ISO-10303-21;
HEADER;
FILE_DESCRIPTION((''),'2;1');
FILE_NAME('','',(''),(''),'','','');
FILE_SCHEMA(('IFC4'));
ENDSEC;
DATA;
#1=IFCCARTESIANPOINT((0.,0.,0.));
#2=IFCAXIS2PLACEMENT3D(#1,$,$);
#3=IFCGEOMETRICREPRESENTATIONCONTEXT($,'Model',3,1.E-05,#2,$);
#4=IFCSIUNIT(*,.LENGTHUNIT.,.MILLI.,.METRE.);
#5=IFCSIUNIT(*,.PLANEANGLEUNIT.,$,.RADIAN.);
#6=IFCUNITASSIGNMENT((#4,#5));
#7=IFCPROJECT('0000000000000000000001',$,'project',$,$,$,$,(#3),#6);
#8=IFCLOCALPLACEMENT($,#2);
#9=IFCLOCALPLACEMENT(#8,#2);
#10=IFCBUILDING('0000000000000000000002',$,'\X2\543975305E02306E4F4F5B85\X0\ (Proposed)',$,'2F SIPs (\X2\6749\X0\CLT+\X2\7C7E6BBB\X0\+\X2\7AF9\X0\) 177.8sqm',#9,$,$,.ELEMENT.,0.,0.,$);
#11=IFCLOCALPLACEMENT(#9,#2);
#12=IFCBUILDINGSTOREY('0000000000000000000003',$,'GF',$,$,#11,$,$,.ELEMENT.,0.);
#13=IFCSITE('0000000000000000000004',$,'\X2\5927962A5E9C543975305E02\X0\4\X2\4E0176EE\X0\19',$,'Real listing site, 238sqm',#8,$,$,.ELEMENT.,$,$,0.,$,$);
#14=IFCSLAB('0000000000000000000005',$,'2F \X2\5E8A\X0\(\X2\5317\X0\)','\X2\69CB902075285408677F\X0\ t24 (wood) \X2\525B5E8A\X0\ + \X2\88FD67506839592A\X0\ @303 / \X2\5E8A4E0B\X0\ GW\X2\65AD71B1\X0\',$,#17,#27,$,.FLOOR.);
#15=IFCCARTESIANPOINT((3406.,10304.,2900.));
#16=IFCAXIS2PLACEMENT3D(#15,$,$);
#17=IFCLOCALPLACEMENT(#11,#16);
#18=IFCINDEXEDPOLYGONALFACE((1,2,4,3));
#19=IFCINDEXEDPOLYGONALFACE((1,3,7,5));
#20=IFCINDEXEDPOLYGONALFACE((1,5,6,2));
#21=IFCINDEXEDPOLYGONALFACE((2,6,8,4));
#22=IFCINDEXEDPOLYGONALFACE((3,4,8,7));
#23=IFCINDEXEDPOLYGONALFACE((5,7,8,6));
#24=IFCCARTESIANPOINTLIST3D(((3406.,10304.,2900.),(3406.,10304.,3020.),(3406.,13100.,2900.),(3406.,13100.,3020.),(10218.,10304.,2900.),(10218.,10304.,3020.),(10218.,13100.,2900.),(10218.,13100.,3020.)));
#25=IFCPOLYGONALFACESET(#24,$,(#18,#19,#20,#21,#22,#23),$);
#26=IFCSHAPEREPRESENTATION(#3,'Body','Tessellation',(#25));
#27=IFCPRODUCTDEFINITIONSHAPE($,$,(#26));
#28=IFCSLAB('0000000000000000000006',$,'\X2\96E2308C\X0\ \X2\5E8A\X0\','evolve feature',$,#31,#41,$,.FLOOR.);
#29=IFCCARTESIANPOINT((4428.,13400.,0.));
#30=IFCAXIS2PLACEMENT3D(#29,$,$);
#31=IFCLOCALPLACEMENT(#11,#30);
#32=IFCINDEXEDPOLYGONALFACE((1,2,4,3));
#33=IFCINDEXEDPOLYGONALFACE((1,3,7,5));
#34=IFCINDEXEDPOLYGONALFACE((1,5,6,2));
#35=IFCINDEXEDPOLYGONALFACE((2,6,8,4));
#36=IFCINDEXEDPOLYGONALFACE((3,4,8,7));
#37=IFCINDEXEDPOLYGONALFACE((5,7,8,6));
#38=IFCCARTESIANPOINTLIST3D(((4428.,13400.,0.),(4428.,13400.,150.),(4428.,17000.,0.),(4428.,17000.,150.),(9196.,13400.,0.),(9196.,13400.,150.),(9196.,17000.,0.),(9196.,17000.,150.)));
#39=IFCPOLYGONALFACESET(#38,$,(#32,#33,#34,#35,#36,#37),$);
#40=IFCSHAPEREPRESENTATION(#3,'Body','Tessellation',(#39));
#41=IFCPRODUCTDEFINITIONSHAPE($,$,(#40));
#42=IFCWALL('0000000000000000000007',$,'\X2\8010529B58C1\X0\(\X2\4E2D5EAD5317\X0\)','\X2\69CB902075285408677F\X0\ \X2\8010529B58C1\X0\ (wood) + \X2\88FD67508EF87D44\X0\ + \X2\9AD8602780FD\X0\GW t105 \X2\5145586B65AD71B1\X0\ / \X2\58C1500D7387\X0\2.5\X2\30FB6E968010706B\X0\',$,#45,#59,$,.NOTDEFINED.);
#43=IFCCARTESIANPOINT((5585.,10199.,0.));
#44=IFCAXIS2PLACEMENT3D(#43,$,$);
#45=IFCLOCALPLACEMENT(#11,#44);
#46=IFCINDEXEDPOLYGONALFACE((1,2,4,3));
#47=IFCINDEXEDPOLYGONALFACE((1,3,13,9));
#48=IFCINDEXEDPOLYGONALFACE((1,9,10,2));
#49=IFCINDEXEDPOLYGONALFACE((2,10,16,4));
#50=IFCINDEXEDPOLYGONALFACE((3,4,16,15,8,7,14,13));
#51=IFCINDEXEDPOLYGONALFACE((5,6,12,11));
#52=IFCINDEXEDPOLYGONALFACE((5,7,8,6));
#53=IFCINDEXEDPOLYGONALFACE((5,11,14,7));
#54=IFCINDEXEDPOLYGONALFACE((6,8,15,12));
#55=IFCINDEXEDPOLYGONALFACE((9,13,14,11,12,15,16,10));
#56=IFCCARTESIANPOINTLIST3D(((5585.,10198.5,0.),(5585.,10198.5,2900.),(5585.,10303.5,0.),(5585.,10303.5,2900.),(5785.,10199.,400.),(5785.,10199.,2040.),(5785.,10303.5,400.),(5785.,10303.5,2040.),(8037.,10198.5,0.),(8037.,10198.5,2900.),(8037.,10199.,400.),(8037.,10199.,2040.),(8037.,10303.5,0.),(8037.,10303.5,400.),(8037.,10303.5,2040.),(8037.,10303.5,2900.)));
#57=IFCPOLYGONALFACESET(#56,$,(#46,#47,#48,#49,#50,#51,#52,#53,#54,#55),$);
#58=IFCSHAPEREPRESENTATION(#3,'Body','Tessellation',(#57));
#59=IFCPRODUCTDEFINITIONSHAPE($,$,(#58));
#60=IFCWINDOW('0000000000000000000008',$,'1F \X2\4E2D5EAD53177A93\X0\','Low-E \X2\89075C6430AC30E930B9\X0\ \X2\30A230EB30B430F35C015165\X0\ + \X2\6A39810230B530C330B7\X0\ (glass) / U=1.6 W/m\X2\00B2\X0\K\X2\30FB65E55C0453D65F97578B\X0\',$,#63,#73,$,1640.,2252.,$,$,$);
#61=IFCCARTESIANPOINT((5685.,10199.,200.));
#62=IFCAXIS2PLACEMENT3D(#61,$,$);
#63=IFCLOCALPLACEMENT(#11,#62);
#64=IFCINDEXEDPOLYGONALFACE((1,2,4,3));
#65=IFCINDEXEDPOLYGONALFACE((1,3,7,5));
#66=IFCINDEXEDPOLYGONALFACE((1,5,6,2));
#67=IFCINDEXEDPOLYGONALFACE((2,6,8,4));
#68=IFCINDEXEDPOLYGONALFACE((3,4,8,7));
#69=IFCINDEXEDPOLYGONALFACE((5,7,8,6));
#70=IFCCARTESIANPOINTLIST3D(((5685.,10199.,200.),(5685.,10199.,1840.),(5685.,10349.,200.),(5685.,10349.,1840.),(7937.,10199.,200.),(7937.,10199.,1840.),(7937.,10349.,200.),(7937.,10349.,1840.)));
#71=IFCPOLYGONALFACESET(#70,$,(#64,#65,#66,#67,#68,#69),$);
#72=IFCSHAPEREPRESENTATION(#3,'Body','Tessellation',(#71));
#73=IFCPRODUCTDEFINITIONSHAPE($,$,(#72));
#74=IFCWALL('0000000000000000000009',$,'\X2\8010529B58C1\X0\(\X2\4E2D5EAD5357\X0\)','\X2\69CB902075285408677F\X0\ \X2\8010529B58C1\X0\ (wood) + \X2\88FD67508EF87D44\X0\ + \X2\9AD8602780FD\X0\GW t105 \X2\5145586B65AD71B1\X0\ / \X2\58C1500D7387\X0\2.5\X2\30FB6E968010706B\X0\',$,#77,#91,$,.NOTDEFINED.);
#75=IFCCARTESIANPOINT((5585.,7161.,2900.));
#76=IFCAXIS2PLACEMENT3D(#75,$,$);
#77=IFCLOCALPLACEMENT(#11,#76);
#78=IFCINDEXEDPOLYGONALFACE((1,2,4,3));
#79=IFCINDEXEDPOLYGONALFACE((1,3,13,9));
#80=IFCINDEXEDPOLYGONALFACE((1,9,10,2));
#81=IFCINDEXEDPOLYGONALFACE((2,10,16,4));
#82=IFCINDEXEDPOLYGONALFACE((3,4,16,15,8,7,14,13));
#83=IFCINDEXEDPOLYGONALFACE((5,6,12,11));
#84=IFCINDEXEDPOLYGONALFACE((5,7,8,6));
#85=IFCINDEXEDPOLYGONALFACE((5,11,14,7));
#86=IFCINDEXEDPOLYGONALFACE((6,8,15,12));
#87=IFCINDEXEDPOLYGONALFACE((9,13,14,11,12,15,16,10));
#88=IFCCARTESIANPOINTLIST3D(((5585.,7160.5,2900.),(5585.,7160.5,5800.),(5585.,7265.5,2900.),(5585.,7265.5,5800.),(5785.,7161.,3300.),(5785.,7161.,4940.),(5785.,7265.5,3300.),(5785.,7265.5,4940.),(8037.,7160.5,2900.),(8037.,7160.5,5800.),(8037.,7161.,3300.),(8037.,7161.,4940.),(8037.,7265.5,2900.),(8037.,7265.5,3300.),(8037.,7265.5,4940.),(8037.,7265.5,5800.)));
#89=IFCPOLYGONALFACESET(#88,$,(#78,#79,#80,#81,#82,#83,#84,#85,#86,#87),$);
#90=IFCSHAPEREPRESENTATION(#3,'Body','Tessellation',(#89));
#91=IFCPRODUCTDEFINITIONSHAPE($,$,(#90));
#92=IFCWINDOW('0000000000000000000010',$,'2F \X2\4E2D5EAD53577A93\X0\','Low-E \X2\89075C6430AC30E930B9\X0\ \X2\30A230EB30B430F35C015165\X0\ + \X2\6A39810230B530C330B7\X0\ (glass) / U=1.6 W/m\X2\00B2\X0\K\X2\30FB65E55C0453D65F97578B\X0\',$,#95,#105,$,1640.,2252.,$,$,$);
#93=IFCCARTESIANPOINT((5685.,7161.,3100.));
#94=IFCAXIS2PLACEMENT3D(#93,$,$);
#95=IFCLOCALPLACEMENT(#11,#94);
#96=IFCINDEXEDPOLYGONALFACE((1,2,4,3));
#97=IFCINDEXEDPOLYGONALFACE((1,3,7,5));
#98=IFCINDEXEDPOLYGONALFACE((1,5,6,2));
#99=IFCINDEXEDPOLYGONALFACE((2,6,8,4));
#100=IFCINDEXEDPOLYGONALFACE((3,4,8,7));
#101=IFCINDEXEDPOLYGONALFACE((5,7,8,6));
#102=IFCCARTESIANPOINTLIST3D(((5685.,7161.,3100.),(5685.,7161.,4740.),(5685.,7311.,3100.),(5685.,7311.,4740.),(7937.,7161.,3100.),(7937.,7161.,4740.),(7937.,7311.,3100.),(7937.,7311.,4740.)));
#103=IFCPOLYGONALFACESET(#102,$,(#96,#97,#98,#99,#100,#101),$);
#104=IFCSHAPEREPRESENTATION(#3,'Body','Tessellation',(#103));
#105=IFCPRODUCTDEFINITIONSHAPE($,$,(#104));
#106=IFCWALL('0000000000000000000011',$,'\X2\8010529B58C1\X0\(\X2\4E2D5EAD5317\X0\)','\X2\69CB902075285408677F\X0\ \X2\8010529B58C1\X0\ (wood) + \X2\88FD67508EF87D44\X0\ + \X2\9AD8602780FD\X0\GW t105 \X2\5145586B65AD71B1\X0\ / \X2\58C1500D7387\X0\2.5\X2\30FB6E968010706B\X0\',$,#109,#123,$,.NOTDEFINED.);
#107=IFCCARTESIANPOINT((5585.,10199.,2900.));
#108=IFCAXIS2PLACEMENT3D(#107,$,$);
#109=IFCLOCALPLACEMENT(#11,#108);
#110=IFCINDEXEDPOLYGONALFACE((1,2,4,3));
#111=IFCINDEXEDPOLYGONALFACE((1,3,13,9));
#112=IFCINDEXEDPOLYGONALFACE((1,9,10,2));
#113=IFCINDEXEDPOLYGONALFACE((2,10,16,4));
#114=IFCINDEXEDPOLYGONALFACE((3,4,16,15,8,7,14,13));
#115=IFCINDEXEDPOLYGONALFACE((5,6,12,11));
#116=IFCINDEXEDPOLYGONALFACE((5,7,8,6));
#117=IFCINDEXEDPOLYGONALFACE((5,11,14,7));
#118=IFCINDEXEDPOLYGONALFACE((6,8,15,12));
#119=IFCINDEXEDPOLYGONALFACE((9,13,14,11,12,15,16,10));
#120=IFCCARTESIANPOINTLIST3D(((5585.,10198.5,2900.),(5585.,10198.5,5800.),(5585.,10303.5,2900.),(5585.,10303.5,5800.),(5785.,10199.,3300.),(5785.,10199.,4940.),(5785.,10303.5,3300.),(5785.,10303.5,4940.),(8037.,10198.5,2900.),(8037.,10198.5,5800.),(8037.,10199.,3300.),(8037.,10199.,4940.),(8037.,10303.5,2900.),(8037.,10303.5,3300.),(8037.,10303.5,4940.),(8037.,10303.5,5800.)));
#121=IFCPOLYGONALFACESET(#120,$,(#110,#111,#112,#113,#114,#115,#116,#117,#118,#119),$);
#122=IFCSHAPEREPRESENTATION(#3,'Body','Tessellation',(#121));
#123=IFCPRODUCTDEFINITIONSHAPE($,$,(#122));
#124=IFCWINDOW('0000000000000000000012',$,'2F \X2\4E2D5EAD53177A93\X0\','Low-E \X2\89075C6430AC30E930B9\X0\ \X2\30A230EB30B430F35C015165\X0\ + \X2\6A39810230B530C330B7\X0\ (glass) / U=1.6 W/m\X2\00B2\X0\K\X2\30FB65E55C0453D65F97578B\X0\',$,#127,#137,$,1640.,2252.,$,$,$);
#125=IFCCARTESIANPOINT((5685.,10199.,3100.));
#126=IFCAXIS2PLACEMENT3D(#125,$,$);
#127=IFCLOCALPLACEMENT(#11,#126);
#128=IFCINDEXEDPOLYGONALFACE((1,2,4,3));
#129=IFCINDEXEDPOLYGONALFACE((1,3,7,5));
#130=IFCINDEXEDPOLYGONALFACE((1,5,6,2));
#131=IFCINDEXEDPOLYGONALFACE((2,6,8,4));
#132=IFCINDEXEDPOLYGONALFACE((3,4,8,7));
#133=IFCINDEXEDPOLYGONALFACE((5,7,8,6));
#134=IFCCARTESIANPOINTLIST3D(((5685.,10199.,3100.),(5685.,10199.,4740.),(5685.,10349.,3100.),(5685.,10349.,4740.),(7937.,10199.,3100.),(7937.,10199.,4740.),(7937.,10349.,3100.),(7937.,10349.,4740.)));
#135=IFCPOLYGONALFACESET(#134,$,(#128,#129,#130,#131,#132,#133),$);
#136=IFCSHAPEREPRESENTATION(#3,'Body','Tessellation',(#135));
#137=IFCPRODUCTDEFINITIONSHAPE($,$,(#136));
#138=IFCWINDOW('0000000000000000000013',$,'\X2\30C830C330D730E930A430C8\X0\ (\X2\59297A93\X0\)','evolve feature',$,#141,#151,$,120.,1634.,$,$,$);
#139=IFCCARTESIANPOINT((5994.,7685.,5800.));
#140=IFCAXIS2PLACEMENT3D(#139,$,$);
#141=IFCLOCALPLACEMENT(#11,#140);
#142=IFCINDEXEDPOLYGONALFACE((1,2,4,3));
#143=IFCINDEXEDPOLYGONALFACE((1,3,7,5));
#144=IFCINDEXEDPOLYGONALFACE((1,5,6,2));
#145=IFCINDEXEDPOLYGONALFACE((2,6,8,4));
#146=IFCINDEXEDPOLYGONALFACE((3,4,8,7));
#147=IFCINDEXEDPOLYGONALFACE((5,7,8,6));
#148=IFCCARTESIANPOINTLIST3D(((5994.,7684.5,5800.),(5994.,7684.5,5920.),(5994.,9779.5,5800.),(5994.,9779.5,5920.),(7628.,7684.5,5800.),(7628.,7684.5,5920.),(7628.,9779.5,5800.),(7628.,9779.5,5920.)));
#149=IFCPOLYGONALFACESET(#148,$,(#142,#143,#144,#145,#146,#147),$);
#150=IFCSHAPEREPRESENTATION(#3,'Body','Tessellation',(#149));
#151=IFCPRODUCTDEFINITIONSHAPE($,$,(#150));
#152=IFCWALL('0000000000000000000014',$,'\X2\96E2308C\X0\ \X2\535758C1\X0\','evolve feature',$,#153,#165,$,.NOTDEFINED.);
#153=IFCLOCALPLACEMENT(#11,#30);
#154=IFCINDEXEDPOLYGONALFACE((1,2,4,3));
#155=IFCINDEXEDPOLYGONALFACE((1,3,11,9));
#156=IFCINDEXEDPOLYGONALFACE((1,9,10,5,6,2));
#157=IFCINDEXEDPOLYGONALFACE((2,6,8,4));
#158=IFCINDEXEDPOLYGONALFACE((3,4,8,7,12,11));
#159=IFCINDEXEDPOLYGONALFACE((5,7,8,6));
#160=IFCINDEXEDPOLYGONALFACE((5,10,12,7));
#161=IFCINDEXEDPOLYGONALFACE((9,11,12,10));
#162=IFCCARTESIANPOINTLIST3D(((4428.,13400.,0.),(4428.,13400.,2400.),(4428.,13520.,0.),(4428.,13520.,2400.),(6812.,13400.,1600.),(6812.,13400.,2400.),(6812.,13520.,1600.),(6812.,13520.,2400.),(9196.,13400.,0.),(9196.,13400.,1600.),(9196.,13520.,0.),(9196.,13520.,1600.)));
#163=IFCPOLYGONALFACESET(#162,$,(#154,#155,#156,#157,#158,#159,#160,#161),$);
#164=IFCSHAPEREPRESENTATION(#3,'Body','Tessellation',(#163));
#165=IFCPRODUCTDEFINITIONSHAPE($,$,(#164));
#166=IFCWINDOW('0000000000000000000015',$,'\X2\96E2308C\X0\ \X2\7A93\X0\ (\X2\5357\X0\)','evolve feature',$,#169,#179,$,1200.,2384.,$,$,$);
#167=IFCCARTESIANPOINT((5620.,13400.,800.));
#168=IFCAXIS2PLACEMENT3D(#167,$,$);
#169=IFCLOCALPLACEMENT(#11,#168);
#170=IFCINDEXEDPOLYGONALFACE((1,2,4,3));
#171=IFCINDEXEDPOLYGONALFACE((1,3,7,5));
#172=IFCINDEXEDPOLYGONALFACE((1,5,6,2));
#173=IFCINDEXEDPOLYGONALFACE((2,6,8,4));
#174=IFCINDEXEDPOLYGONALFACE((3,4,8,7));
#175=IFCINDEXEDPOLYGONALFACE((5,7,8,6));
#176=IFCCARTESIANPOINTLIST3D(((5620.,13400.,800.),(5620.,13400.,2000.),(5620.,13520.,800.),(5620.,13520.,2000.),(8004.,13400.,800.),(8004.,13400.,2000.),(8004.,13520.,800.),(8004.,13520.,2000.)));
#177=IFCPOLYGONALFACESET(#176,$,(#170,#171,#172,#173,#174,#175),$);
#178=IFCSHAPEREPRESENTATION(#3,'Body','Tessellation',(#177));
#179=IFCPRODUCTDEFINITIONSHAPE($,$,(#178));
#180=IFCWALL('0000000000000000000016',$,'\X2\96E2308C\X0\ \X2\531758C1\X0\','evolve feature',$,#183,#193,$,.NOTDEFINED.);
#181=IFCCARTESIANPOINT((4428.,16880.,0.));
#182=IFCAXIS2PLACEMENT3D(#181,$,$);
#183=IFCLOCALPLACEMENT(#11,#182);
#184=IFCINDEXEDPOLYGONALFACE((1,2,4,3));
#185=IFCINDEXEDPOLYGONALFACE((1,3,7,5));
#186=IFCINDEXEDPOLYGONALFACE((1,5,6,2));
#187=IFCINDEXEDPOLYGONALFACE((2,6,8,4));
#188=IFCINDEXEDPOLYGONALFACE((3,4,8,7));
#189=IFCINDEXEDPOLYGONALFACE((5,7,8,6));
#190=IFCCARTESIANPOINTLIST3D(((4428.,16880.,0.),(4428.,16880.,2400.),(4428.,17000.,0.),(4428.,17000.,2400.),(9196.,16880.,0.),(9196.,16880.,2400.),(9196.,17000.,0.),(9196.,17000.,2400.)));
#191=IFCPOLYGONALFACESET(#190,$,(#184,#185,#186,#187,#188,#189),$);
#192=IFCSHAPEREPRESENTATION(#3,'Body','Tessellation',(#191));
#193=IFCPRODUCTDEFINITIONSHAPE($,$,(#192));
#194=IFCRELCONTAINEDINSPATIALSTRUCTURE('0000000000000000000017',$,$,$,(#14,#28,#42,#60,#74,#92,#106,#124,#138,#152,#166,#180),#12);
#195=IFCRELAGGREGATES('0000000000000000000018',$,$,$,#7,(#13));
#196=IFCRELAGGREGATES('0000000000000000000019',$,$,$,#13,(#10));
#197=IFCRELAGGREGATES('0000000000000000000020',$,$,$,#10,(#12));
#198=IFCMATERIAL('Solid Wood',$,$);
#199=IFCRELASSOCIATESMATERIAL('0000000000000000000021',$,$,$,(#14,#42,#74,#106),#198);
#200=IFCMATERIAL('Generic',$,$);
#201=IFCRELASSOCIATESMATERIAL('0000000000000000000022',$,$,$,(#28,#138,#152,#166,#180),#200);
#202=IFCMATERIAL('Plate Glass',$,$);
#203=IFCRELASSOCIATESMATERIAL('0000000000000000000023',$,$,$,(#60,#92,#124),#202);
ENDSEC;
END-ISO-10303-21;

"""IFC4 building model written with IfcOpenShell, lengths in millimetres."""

from ifc_helpers import new_model, si_unit, frame, frame_2d, origin, place, context, project, spatial, rectangle, extrude, material, element, fill, save


model = new_model("IFC4")

# Units and contexts
model_context = context("Model", 3, precision=1e-05, world=origin())
ifc_project = project(units=[si_unit("LENGTHUNIT", "METRE", prefix="MILLI"), si_unit("PLANEANGLEUNIT", "RADIAN")], contexts=[model_context])

# Site, building, storey
site_placement = place(None, origin())
site = spatial("IfcSite", under=ifc_project, at=site_placement, Name="大阪府吹田市4丁目19", ObjectType="Real listing site, 238sqm", CompositionType="ELEMENT", RefElevation=0.0)
building_placement = place(site_placement, origin())
building = spatial("IfcBuilding", under=site, at=building_placement, Name="吹田市の住宅 (Proposed)", ObjectType="2F SIPs (杉CLT+籾殻+竹) 177.8sqm", CompositionType="ELEMENT", ElevationOfRefHeight=0.0, ElevationOfTerrain=0.0)
storey_placement = place(building_placement, origin())
storey = spatial("IfcBuildingStorey", under=building, at=storey_placement, Name="GF", CompositionType="ELEMENT", Elevation=0.0)

# Slabs
ifc_material_1 = material(Name="Solid Wood")
slab_1_placement = place(storey_placement, frame((3406.0, 10304.0, 2900.0)))
element("IfcSlab", 1, at=slab_1_placement, inside=storey, material=ifc_material_1, Name="2F 床(北)", Description="構造用合板 t24 (wood) 剛床 + 製材根太 @303 / 床下 GW断熱", PredefinedType="FLOOR", context=model_context, shape_type="SweptSolid", body=[
    extrude(rectangle(XDim=6812.0, YDim=2796.0, at=frame_2d((3406.0, 1398.0))), frame((3406.0, 10304.0, 2900.0)), (0.0, 0.0, 1.0), 120.0),
])
ifc_material_2 = material(Name="Generic")
slab_2_placement = place(storey_placement, frame((4428.0, 13400.0, 0.0)))
element("IfcSlab", 2, at=slab_2_placement, inside=storey, material=ifc_material_2, Name="離れ 床", Description="evolve feature", PredefinedType="FLOOR", context=model_context, shape_type="SweptSolid", body=[
    extrude(rectangle(XDim=4768.0, YDim=3600.0, at=frame_2d((2384.0, 1800.0))), frame((4428.0, 13400.0, 0.0)), (0.0, 0.0, 1.0), 150.0),
])

# Wall, opening, window
wall_1_placement = place(storey_placement, frame((5585.0, 10199.0, 0.0)))
wall_1 = element("IfcWall", 3, at=wall_1_placement, inside=storey, material=ifc_material_1, Name="耐力壁(中庭北)", Description="構造用合板 耐力壁 (wood) + 製材軸組 + 高性能GW t105 充填断熱 / 壁倍率2.5・準耐火", PredefinedType="NOTDEFINED", context=model_context, shape_type="SweptSolid", body=[
    extrude(rectangle(XDim=2452.0, YDim=105.0, at=frame_2d((1226.0, 52.0))), frame((5585.0, 10199.0, 0.0)), (0.0, 0.0, 1.0), 2900.0),
])
opening_1_placement = place(storey_placement, frame((5685.0, 10199.0, 200.0)))
opening_1 = element("IfcOpeningElement", 4, at=opening_1_placement, cuts=wall_1, PredefinedType="NOTDEFINED", context=model_context, shape_type="SweptSolid", body=[
    extrude(rectangle(XDim=2252.0, YDim=150.0, at=frame_2d((1126.0, 75.0))), frame((5685.0, 10199.0, 200.0)), (0.0, 0.0, 1.0), 1640.0),
])
ifc_material_3 = material(Name="Plate Glass")
window_1_placement = place(storey_placement, frame((5685.0, 10199.0, 200.0)))
window_1 = element("IfcWindow", 5, at=window_1_placement, inside=storey, material=ifc_material_3, Name="1F 中庭北窓", Description="Low-E 複層ガラス アルゴン封入 + 樹脂サッシ (glass) / U=1.6 W/m²K・日射取得型", OverallHeight=1640.0, OverallWidth=2252.0, context=model_context, shape_type="SweptSolid", body=[
    extrude(rectangle(XDim=2252.0, YDim=150.0, at=frame_2d((1126.0, 75.0))), frame((5685.0, 10199.0, 200.0)), (0.0, 0.0, 1.0), 1640.0),
])
fill(opening_1, window_1)

# Walls, openings, windows
wall_2_placement = place(storey_placement, frame((5585.0, 7161.0, 2900.0)))
wall_2 = element("IfcWall", 6, at=wall_2_placement, inside=storey, material=ifc_material_1, Name="耐力壁(中庭南)", Description="構造用合板 耐力壁 (wood) + 製材軸組 + 高性能GW t105 充填断熱 / 壁倍率2.5・準耐火", PredefinedType="NOTDEFINED", context=model_context, shape_type="SweptSolid", body=[
    extrude(rectangle(XDim=2452.0, YDim=105.0, at=frame_2d((1226.0, 52.0))), frame((5585.0, 7161.0, 2900.0)), (0.0, 0.0, 1.0), 2900.0),
])
opening_2_placement = place(storey_placement, frame((5685.0, 7161.0, 3100.0)))
opening_2 = element("IfcOpeningElement", 7, at=opening_2_placement, cuts=wall_2, PredefinedType="NOTDEFINED", context=model_context, shape_type="SweptSolid", body=[
    extrude(rectangle(XDim=2252.0, YDim=150.0, at=frame_2d((1126.0, 75.0))), frame((5685.0, 7161.0, 3100.0)), (0.0, 0.0, 1.0), 1640.0),
])
window_2_placement = place(storey_placement, frame((5685.0, 7161.0, 3100.0)))
window_2 = element("IfcWindow", 8, at=window_2_placement, inside=storey, material=ifc_material_3, Name="2F 中庭南窓", Description="Low-E 複層ガラス アルゴン封入 + 樹脂サッシ (glass) / U=1.6 W/m²K・日射取得型", OverallHeight=1640.0, OverallWidth=2252.0, context=model_context, shape_type="SweptSolid", body=[
    extrude(rectangle(XDim=2252.0, YDim=150.0, at=frame_2d((1126.0, 75.0))), frame((5685.0, 7161.0, 3100.0)), (0.0, 0.0, 1.0), 1640.0),
])
fill(opening_2, window_2)
wall_3_placement = place(storey_placement, frame((5585.0, 10199.0, 2900.0)))
wall_3 = element("IfcWall", 9, at=wall_3_placement, inside=storey, material=ifc_material_1, Name="耐力壁(中庭北)", Description="構造用合板 耐力壁 (wood) + 製材軸組 + 高性能GW t105 充填断熱 / 壁倍率2.5・準耐火", PredefinedType="NOTDEFINED", context=model_context, shape_type="SweptSolid", body=[
    extrude(rectangle(XDim=2452.0, YDim=105.0, at=frame_2d((1226.0, 52.0))), frame((5585.0, 10199.0, 2900.0)), (0.0, 0.0, 1.0), 2900.0),
])
opening_3_placement = place(storey_placement, frame((5685.0, 10199.0, 3100.0)))
opening_3 = element("IfcOpeningElement", 10, at=opening_3_placement, cuts=wall_3, PredefinedType="NOTDEFINED", context=model_context, shape_type="SweptSolid", body=[
    extrude(rectangle(XDim=2252.0, YDim=150.0, at=frame_2d((1126.0, 75.0))), frame((5685.0, 10199.0, 3100.0)), (0.0, 0.0, 1.0), 1640.0),
])
window_3_placement = place(storey_placement, frame((5685.0, 10199.0, 3100.0)))
window_3 = element("IfcWindow", 11, at=window_3_placement, inside=storey, material=ifc_material_3, Name="2F 中庭北窓", Description="Low-E 複層ガラス アルゴン封入 + 樹脂サッシ (glass) / U=1.6 W/m²K・日射取得型", OverallHeight=1640.0, OverallWidth=2252.0, context=model_context, shape_type="SweptSolid", body=[
    extrude(rectangle(XDim=2252.0, YDim=150.0, at=frame_2d((1126.0, 75.0))), frame((5685.0, 10199.0, 3100.0)), (0.0, 0.0, 1.0), 1640.0),
])
fill(opening_3, window_3)

# Window
window_4_placement = place(storey_placement, frame((5994.0, 7685.0, 5800.0)))
element("IfcWindow", 12, at=window_4_placement, inside=storey, material=ifc_material_2, Name="トップライト (天窓)", Description="evolve feature", OverallHeight=120.0, OverallWidth=1634.0, context=model_context, shape_type="SweptSolid", body=[
    extrude(rectangle(XDim=1634.0, YDim=2095.0, at=frame_2d((817.0, 1047.0))), frame((5994.0, 7685.0, 5800.0)), (0.0, 0.0, 1.0), 120.0),
])

# Wall, opening, window
wall_4_placement = place(storey_placement, frame((4428.0, 13400.0, 0.0)))
wall_4 = element("IfcWall", 13, at=wall_4_placement, inside=storey, material=ifc_material_2, Name="離れ 南壁", Description="evolve feature", PredefinedType="NOTDEFINED", context=model_context, shape_type="SweptSolid", body=[
    extrude(rectangle(XDim=4768.0, YDim=120.0, at=frame_2d((2384.0, 60.0))), frame((4428.0, 13400.0, 0.0)), (0.0, 0.0, 1.0), 2400.0),
])
opening_4_placement = place(storey_placement, frame((5620.0, 13400.0, 800.0)))
opening_4 = element("IfcOpeningElement", 14, at=opening_4_placement, cuts=wall_4, PredefinedType="NOTDEFINED", context=model_context, shape_type="SweptSolid", body=[
    extrude(rectangle(XDim=2384.0, YDim=120.0, at=frame_2d((1192.0, 60.0))), frame((5620.0, 13400.0, 800.0)), (0.0, 0.0, 1.0), 1200.0),
])
window_5_placement = place(storey_placement, frame((5620.0, 13400.0, 800.0)))
window_5 = element("IfcWindow", 15, at=window_5_placement, inside=storey, material=ifc_material_2, Name="離れ 窓 (南)", Description="evolve feature", OverallHeight=1200.0, OverallWidth=2384.0, context=model_context, shape_type="SweptSolid", body=[
    extrude(rectangle(XDim=2384.0, YDim=120.0, at=frame_2d((1192.0, 60.0))), frame((5620.0, 13400.0, 800.0)), (0.0, 0.0, 1.0), 1200.0),
])
fill(opening_4, window_5)

# Wall
wall_5_placement = place(storey_placement, frame((4428.0, 16880.0, 0.0)))
element("IfcWall", 16, at=wall_5_placement, inside=storey, material=ifc_material_2, Name="離れ 北壁", Description="evolve feature", PredefinedType="NOTDEFINED", context=model_context, shape_type="SweptSolid", body=[
    extrude(rectangle(XDim=4768.0, YDim=120.0, at=frame_2d((2384.0, 60.0))), frame((4428.0, 16880.0, 0.0)), (0.0, 0.0, 1.0), 2400.0),
])

save(model, "model.ifc")
